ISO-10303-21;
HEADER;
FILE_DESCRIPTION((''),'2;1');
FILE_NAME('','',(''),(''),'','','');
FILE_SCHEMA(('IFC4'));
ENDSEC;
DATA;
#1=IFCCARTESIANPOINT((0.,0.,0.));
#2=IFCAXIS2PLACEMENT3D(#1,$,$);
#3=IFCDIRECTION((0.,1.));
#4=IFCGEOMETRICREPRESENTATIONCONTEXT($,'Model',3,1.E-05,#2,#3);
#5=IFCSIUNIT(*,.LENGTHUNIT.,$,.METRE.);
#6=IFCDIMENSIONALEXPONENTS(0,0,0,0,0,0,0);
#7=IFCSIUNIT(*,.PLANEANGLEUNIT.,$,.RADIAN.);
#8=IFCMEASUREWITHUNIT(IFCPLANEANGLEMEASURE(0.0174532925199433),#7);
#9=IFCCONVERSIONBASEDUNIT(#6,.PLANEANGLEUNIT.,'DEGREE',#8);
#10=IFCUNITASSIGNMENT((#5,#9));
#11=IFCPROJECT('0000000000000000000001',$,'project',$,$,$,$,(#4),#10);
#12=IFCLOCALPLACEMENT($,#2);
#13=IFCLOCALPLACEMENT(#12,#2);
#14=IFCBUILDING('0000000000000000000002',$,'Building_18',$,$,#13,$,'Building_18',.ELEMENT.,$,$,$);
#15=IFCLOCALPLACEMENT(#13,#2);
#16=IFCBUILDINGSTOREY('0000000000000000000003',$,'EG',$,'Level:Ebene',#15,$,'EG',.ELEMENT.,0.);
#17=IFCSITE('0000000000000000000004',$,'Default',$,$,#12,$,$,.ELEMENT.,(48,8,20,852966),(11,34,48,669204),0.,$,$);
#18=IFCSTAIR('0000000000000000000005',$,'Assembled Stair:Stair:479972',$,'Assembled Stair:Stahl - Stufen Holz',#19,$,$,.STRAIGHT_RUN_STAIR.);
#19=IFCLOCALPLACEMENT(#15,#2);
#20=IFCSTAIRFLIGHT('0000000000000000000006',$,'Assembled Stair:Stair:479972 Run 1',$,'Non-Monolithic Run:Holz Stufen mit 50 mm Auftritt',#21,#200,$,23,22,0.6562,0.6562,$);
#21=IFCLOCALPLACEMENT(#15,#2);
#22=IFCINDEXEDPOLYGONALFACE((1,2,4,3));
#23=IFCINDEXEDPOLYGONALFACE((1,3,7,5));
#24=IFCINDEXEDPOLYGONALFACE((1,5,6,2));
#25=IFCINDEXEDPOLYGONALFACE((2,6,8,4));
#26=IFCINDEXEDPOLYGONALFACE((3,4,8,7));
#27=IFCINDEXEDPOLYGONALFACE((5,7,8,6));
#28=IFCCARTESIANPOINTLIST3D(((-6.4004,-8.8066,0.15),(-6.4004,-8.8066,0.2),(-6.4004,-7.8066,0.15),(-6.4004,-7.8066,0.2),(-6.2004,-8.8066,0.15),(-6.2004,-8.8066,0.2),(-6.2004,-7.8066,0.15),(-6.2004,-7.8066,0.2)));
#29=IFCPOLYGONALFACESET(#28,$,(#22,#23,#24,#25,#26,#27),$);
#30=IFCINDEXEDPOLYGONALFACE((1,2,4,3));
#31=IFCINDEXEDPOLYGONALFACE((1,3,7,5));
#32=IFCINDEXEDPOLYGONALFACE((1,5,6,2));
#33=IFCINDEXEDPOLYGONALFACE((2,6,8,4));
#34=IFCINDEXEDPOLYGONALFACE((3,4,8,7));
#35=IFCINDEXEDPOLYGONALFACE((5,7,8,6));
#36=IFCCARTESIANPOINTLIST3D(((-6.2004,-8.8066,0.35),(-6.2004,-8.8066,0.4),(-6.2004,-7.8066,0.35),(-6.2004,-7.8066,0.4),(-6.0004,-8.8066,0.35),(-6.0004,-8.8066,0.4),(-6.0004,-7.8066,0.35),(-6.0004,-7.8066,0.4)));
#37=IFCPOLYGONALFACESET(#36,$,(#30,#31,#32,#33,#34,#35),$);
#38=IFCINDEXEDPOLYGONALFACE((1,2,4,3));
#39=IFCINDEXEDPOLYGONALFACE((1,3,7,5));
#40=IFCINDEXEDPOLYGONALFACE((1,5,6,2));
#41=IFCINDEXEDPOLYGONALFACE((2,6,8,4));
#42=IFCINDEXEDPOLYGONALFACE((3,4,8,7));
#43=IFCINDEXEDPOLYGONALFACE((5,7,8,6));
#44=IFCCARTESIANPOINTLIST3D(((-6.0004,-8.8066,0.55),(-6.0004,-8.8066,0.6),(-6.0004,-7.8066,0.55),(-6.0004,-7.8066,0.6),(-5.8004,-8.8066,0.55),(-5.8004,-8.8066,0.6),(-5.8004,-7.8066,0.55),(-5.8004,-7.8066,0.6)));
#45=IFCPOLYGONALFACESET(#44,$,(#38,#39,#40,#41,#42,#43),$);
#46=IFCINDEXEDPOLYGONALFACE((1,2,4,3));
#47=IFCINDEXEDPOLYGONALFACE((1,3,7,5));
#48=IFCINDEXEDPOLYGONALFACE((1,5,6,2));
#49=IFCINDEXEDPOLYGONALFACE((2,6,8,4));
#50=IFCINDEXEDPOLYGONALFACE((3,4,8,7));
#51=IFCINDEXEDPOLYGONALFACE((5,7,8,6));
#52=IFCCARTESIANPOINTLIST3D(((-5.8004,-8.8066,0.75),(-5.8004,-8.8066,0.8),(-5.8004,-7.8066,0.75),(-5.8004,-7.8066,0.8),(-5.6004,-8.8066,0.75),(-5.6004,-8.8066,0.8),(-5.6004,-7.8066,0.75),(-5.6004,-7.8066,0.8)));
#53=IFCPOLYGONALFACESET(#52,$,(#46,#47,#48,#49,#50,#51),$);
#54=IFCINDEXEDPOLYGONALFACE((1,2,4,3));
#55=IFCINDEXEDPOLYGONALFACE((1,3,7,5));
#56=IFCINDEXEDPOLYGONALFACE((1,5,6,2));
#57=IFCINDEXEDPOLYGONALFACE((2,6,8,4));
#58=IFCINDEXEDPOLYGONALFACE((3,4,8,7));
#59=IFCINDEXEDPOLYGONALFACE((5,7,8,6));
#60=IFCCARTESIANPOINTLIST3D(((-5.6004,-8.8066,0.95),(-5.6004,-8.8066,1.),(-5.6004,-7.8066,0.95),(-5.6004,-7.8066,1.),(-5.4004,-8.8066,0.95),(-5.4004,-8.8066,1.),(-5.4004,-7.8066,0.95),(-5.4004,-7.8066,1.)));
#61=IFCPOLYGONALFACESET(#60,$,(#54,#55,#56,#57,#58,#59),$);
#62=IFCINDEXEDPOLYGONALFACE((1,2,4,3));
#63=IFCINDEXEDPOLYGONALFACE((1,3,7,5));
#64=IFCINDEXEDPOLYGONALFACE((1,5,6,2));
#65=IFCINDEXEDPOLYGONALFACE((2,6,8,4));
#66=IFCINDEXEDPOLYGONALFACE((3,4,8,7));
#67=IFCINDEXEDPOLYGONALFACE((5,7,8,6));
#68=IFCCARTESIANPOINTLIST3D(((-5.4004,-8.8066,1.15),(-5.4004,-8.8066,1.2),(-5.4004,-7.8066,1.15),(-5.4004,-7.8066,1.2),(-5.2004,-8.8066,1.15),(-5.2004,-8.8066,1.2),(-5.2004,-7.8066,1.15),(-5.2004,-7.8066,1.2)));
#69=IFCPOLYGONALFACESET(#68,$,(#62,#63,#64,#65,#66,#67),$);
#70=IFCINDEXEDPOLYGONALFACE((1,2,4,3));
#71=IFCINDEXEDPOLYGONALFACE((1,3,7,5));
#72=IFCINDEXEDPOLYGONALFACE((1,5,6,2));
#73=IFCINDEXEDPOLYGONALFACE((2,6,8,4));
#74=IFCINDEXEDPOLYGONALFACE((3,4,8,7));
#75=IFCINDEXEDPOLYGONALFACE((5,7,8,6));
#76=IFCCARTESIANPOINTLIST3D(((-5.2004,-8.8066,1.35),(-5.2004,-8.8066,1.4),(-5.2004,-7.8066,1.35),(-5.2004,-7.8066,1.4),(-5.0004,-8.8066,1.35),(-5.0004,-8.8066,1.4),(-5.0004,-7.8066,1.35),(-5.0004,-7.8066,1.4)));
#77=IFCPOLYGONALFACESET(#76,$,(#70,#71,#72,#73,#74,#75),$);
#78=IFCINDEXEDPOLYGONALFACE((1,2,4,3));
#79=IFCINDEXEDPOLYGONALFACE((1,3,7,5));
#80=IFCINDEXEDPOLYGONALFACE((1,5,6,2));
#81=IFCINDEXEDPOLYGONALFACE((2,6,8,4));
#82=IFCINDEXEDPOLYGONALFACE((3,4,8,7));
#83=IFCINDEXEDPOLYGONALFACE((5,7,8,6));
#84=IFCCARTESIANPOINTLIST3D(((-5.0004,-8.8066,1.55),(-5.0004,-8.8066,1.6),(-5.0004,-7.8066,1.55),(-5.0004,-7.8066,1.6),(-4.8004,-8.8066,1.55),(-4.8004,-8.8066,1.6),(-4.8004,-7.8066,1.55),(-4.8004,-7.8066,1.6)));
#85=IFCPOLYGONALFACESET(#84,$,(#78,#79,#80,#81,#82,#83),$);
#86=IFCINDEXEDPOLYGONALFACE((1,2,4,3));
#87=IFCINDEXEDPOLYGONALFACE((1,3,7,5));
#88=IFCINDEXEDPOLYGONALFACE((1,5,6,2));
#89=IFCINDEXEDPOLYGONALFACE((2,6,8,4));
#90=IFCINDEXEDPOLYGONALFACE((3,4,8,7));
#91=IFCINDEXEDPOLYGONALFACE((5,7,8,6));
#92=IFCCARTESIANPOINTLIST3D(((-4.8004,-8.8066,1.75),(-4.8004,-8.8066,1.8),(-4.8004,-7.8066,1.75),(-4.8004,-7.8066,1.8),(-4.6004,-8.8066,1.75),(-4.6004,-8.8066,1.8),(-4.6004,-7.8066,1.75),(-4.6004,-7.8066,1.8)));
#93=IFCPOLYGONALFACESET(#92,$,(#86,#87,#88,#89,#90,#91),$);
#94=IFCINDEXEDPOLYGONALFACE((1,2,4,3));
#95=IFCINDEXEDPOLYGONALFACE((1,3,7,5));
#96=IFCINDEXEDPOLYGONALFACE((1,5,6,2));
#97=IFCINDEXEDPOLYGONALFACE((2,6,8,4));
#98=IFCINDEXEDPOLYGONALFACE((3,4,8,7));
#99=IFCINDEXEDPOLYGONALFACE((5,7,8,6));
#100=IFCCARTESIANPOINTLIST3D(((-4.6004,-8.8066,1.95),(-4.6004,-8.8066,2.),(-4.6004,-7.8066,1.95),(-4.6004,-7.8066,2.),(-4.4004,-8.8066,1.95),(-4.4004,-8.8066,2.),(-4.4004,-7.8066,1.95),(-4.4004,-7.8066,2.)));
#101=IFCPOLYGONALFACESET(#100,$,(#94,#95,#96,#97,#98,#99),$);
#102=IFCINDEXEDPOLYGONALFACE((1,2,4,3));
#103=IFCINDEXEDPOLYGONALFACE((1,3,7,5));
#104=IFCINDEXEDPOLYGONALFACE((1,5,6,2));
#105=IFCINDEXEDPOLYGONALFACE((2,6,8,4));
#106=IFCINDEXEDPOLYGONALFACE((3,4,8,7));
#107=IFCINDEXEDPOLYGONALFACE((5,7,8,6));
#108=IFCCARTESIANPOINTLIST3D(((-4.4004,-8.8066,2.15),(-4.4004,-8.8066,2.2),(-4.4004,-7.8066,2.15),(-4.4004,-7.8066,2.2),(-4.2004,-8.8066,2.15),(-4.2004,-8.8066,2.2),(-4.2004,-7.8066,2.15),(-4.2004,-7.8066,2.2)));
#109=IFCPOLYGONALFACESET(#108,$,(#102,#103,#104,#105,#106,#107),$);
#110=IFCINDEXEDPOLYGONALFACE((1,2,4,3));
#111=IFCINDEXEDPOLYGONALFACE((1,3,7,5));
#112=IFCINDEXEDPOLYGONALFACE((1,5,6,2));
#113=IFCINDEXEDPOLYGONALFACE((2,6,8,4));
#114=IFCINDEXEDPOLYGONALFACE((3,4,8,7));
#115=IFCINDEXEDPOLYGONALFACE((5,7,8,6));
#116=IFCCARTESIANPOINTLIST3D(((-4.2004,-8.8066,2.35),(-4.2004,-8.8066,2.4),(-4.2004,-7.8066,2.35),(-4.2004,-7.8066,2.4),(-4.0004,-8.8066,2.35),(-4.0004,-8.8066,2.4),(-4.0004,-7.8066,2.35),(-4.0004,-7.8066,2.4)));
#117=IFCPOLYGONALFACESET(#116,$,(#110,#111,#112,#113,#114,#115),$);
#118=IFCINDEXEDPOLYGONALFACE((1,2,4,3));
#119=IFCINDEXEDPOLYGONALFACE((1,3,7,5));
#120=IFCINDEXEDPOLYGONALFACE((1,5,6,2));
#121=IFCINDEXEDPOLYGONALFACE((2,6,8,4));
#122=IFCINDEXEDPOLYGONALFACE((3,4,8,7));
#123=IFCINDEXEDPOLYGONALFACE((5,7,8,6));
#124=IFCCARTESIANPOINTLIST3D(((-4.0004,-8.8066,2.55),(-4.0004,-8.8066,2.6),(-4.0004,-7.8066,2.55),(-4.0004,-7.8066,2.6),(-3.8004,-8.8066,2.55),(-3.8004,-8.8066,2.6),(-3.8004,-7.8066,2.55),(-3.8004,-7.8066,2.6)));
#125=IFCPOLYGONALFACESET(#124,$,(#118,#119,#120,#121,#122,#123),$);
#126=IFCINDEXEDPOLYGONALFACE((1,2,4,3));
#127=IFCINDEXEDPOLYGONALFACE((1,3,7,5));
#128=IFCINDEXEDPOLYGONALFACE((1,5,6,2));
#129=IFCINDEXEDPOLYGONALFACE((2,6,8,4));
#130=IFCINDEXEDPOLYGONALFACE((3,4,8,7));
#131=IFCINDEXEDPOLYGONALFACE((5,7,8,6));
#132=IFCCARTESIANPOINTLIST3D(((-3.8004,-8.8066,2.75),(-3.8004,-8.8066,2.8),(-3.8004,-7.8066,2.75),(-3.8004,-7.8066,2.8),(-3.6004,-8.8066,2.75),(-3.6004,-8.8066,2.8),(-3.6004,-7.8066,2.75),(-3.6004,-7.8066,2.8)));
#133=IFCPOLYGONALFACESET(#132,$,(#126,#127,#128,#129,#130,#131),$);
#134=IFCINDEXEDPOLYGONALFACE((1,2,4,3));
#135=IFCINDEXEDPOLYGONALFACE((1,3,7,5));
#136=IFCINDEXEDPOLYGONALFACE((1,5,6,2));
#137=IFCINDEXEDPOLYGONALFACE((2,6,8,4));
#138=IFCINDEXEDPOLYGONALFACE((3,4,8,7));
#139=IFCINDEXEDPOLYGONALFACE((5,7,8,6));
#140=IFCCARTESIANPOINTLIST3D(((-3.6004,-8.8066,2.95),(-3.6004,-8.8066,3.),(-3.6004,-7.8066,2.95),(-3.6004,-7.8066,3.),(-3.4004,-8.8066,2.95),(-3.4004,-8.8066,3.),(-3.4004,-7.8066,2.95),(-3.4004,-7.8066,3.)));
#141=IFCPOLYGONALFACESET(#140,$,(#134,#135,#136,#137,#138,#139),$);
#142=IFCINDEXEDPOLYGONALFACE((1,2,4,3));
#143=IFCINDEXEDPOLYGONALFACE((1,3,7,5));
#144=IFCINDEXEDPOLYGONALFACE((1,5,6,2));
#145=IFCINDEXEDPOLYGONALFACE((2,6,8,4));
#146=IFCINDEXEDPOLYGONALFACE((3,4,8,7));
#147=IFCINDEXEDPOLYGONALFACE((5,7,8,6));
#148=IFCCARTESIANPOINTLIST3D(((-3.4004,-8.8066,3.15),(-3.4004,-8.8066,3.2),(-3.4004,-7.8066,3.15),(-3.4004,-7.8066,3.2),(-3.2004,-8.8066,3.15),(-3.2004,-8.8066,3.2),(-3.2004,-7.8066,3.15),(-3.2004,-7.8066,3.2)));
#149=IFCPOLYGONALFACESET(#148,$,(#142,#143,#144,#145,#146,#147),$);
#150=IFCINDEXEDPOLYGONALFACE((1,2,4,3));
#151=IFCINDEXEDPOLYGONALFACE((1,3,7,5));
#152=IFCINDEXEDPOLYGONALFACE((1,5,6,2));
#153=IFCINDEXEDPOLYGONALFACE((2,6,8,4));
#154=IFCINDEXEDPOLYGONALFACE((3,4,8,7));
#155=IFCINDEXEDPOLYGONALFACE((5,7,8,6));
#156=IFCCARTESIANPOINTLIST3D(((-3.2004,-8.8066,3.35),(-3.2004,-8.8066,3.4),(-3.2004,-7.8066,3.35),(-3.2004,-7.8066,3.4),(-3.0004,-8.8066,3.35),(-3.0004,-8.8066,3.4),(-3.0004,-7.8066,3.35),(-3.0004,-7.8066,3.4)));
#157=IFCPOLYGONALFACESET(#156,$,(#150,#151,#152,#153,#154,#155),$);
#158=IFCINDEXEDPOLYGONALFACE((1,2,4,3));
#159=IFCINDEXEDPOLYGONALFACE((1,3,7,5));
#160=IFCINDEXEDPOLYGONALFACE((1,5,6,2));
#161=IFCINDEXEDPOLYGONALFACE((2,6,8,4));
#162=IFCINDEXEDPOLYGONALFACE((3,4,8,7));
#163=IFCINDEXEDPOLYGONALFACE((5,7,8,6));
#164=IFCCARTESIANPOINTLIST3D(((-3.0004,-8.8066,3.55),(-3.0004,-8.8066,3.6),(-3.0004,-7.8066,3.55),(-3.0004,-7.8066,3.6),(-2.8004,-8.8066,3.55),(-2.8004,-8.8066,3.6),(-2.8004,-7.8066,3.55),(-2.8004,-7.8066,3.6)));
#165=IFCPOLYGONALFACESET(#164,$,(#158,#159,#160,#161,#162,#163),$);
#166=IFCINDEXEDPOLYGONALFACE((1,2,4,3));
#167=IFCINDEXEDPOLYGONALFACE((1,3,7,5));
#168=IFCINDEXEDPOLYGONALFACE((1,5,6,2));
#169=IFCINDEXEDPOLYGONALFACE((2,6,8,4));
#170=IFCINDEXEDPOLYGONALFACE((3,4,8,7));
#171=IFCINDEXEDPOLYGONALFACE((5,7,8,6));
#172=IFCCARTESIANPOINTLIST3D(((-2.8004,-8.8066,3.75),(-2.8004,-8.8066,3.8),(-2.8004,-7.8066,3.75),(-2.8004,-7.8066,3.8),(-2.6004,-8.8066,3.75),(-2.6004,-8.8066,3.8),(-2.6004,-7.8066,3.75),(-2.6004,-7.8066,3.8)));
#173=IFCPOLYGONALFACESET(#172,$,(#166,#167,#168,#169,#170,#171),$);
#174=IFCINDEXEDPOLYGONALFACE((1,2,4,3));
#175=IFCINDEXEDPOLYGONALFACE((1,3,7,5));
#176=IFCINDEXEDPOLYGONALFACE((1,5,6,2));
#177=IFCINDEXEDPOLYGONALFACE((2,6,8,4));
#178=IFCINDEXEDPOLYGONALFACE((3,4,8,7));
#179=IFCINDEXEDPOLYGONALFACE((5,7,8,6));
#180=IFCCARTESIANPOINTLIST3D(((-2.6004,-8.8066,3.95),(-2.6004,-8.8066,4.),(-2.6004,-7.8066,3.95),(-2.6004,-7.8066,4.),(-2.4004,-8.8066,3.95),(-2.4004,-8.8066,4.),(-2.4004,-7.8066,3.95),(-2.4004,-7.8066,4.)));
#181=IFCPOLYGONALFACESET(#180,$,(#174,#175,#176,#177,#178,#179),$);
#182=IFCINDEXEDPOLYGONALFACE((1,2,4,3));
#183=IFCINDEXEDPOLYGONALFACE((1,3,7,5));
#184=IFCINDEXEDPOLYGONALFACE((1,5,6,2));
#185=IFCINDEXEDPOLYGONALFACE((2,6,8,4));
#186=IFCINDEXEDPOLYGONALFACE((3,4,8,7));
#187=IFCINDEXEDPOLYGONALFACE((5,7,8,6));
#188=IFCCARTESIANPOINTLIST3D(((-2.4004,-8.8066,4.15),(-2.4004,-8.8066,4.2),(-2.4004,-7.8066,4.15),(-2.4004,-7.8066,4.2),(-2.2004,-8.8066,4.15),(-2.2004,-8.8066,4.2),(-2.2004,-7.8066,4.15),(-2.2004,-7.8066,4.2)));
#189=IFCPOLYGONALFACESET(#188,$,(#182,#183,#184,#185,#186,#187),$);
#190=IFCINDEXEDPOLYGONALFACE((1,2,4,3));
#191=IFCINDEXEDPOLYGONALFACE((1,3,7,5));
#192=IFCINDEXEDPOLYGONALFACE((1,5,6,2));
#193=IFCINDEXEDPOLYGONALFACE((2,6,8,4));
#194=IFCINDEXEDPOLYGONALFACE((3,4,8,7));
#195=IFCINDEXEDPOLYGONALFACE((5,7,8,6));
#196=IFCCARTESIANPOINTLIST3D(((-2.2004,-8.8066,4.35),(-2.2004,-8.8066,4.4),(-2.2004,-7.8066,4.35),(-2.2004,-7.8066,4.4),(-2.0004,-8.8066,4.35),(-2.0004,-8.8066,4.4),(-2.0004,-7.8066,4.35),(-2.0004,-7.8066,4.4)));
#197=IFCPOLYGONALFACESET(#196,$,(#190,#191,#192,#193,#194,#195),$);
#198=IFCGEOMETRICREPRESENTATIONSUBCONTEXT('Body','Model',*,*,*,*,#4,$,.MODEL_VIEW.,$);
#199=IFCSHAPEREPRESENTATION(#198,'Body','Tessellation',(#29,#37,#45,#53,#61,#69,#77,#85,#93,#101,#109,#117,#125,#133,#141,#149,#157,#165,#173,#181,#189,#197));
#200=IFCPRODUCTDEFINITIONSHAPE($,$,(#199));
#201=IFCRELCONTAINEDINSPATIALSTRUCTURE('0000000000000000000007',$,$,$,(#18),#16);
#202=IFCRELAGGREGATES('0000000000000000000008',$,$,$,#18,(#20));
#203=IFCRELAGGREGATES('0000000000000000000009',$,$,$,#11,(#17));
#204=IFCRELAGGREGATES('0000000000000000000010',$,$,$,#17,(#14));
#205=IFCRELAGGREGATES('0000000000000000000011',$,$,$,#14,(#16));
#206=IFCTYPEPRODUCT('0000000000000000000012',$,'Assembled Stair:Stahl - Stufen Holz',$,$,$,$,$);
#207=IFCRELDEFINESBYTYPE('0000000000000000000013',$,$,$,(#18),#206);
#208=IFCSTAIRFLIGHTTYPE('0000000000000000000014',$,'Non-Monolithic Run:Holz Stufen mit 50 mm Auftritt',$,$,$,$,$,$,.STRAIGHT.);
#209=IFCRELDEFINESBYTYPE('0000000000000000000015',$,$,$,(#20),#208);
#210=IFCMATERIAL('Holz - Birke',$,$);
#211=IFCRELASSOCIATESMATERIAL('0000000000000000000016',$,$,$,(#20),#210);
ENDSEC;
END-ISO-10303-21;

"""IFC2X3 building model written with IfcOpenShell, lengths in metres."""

from ifc_helpers import new_model, entity, si_unit, converted_unit, direction, frame, frame_2d, origin, origin_2d_with_axis, place, context, subcontext, project, spatial, rectangle, extrude, material, type_object, element, aggregate, save


model = new_model("IFC2X3")

# Units and contexts
model_context = context("Model", 3, precision=1e-05, world=origin(), true_north=direction((0.0, 1.0)))
body_context = subcontext(model_context, "Body", "Model", "MODEL_VIEW")
ifc_project = project(units=[si_unit("LENGTHUNIT", "METRE"), converted_unit("PLANEANGLEUNIT", "DEGREE", entity("IfcPlaneAngleMeasure", 0.0174532925199433), si_unit("PLANEANGLEUNIT", "RADIAN"), dimensions=[0, 0, 0, 0, 0, 0, 0])], contexts=[model_context])

# Site, building, storey
site_placement = place(None, origin())
site = spatial("IfcSite", under=ifc_project, at=site_placement, Name="Default", CompositionType="ELEMENT", RefLatitude=(48, 8, 20, 852966), RefLongitude=(11, 34, 48, 669204), RefElevation=0.0)
building_placement = place(site_placement, origin())
building = spatial("IfcBuilding", under=site, at=building_placement, Name="Building_18", LongName="Building_18", CompositionType="ELEMENT")
storey_placement = place(building_placement, origin())
storey = spatial("IfcBuildingStorey", under=building, at=storey_placement, Name="EG", ObjectType="Level:Ebene", LongName="EG", CompositionType="ELEMENT", Elevation=0.0)

# Stair
type_product = type_object("IfcTypeProduct", Name="Assembled Stair:Stahl - Stufen Holz")
stair_1_placement = place(storey_placement, origin())
stair_1 = element("IfcStair", 1, at=stair_1_placement, inside=storey, type_object=type_product, Name="Assembled Stair:Stair:479972", ObjectType="Assembled Stair:Stahl - Stufen Holz", ShapeType="STRAIGHT_RUN_STAIR")

# Stair flight
ifc_material_1 = material(Name="Holz - Birke")
stair_flight_type = type_object("IfcStairFlightType", Name="Non-Monolithic Run:Holz Stufen mit 50 mm Auftritt", PredefinedType="STRAIGHT")
stair_flight_1_placement = place(stair_1_placement, origin())
stair_flight_1 = element("IfcStairFlight", 2, at=stair_flight_1_placement, type_object=stair_flight_type, material=ifc_material_1, Name="Assembled Stair:Stair:479972 Run 1", ObjectType="Non-Monolithic Run:Holz Stufen mit 50 mm Auftritt", NumberOfRiser=23, NumberOfTreads=22, RiserHeight=0.6562, TreadLength=0.6562, context=body_context, shape_type="SweptSolid", body=[
    extrude(rectangle(XDim=0.2, YDim=1.0, at=frame_2d((0.0, 0.0), x_axis=(1.0, 0.0))), frame((-6.3004, -8.3066, 0.15), z_axis=(0.0, 0.0, 1.0), x_axis=(-1.0, 0.0, 0.0)), (0.0, 0.0, 1.0), 0.05),
    extrude(rectangle(XDim=0.2, YDim=1.0, at=frame_2d((0.0, 0.0), x_axis=(1.0, 0.0))), frame((-6.1004, -8.3066, 0.35), z_axis=(0.0, 0.0, 1.0), x_axis=(-1.0, 0.0, 0.0)), (0.0, 0.0, 1.0), 0.05),
    extrude(rectangle(XDim=0.2, YDim=1.0, at=origin_2d_with_axis()), frame((-5.9004, -8.3066, 0.55), z_axis=(0.0, 0.0, 1.0), x_axis=(-1.0, 0.0, 0.0)), (0.0, 0.0, 1.0), 0.05),
    extrude(rectangle(XDim=0.2, YDim=1.0, at=origin_2d_with_axis()), frame((-5.7004, -8.3066, 0.75), z_axis=(0.0, 0.0, 1.0), x_axis=(-1.0, 0.0, 0.0)), (0.0, 0.0, 1.0), 0.05),
    extrude(rectangle(XDim=0.2, YDim=1.0, at=origin_2d_with_axis()), frame((-5.5004, -8.3066, 0.95), z_axis=(0.0, 0.0, 1.0), x_axis=(-1.0, 0.0, 0.0)), (0.0, 0.0, 1.0), 0.05),
    extrude(rectangle(XDim=0.2, YDim=1.0, at=origin_2d_with_axis()), frame((-5.3004, -8.3066, 1.15), z_axis=(0.0, 0.0, 1.0), x_axis=(-1.0, 0.0, 0.0)), (0.0, 0.0, 1.0), 0.05),
    extrude(rectangle(XDim=0.2, YDim=1.0, at=origin_2d_with_axis()), frame((-5.1004, -8.3066, 1.35), z_axis=(0.0, 0.0, 1.0), x_axis=(-1.0, 0.0, 0.0)), (0.0, 0.0, 1.0), 0.05),
    extrude(rectangle(XDim=0.2, YDim=1.0, at=frame_2d((0.0, 0.0), x_axis=(1.0, 0.0))), frame((-4.9004, -8.3066, 1.55), z_axis=(0.0, 0.0, 1.0), x_axis=(-1.0, 0.0, 0.0)), (0.0, 0.0, 1.0), 0.05),
    extrude(rectangle(XDim=0.2, YDim=1.0, at=frame_2d((0.0, 0.0), x_axis=(1.0, 0.0))), frame((-4.7004, -8.3066, 1.75), z_axis=(0.0, 0.0, 1.0), x_axis=(-1.0, 0.0, 0.0)), (0.0, 0.0, 1.0), 0.05),
    extrude(rectangle(XDim=0.2, YDim=1.0, at=origin_2d_with_axis()), frame((-4.5004, -8.3066, 1.95), z_axis=(0.0, 0.0, 1.0), x_axis=(-1.0, 0.0, 0.0)), (0.0, 0.0, 1.0), 0.05),
    extrude(rectangle(XDim=0.2, YDim=1.0, at=origin_2d_with_axis()), frame((-4.3004, -8.3066, 2.15), z_axis=(0.0, 0.0, 1.0), x_axis=(-1.0, 0.0, 0.0)), (0.0, 0.0, 1.0), 0.05),
    extrude(rectangle(XDim=0.2, YDim=1.0, at=origin_2d_with_axis()), frame((-4.1004, -8.3066, 2.35), z_axis=(0.0, 0.0, 1.0), x_axis=(-1.0, 0.0, 0.0)), (0.0, 0.0, 1.0), 0.05),
    extrude(rectangle(XDim=0.2, YDim=1.0, at=origin_2d_with_axis()), frame((-3.9004, -8.3066, 2.55), z_axis=(0.0, 0.0, 1.0), x_axis=(-1.0, 0.0, 0.0)), (0.0, 0.0, 1.0), 0.05),
    extrude(rectangle(XDim=0.2, YDim=1.0, at=origin_2d_with_axis()), frame((-3.7004, -8.3066, 2.75), z_axis=(0.0, 0.0, 1.0), x_axis=(-1.0, 0.0, 0.0)), (0.0, 0.0, 1.0), 0.05),
    extrude(rectangle(XDim=0.2, YDim=1.0, at=frame_2d((0.0, 0.0), x_axis=(1.0, 0.0))), frame((-3.5004, -8.3066, 2.95), z_axis=(0.0, 0.0, 1.0), x_axis=(-1.0, 0.0, 0.0)), (0.0, 0.0, 1.0), 0.05),
    extrude(rectangle(XDim=0.2, YDim=1.0, at=origin_2d_with_axis()), frame((-3.3004, -8.3066, 3.15), z_axis=(0.0, 0.0, 1.0), x_axis=(-1.0, 0.0, 0.0)), (0.0, 0.0, 1.0), 0.05),
    extrude(rectangle(XDim=0.2, YDim=1.0, at=origin_2d_with_axis()), frame((-3.1004, -8.3066, 3.35), z_axis=(0.0, 0.0, 1.0), x_axis=(-1.0, 0.0, 0.0)), (0.0, 0.0, 1.0), 0.05),
    extrude(rectangle(XDim=0.2, YDim=1.0, at=origin_2d_with_axis()), frame((-2.9004, -8.3066, 3.55), z_axis=(0.0, 0.0, 1.0), x_axis=(-1.0, 0.0, 0.0)), (0.0, 0.0, 1.0), 0.05),
    extrude(rectangle(XDim=0.2, YDim=1.0, at=origin_2d_with_axis()), frame((-2.7004, -8.3066, 3.75), z_axis=(0.0, 0.0, 1.0), x_axis=(-1.0, 0.0, 0.0)), (0.0, 0.0, 1.0), 0.05),
    extrude(rectangle(XDim=0.2, YDim=1.0, at=origin_2d_with_axis()), frame((-2.5004, -8.3066, 3.95), z_axis=(0.0, 0.0, 1.0), x_axis=(-1.0, 0.0, 0.0)), (0.0, 0.0, 1.0), 0.05),
    extrude(rectangle(XDim=0.2, YDim=1.0, at=frame_2d((0.0, 0.0), x_axis=(1.0, 0.0))), frame((-2.3004, -8.3066, 4.15), z_axis=(0.0, 0.0, 1.0), x_axis=(-1.0, 0.0, 0.0)), (0.0, 0.0, 1.0), 0.05),
    extrude(rectangle(XDim=0.2, YDim=1.0, at=frame_2d((0.0, 0.0), x_axis=(1.0, 0.0))), frame((-2.1004, -8.3066, 4.35), z_axis=(0.0, 0.0, 1.0), x_axis=(-1.0, 0.0, 0.0)), (0.0, 0.0, 1.0), 0.05),
])
aggregate(stair_1, [stair_flight_1])

save(model, "model.ifc")
